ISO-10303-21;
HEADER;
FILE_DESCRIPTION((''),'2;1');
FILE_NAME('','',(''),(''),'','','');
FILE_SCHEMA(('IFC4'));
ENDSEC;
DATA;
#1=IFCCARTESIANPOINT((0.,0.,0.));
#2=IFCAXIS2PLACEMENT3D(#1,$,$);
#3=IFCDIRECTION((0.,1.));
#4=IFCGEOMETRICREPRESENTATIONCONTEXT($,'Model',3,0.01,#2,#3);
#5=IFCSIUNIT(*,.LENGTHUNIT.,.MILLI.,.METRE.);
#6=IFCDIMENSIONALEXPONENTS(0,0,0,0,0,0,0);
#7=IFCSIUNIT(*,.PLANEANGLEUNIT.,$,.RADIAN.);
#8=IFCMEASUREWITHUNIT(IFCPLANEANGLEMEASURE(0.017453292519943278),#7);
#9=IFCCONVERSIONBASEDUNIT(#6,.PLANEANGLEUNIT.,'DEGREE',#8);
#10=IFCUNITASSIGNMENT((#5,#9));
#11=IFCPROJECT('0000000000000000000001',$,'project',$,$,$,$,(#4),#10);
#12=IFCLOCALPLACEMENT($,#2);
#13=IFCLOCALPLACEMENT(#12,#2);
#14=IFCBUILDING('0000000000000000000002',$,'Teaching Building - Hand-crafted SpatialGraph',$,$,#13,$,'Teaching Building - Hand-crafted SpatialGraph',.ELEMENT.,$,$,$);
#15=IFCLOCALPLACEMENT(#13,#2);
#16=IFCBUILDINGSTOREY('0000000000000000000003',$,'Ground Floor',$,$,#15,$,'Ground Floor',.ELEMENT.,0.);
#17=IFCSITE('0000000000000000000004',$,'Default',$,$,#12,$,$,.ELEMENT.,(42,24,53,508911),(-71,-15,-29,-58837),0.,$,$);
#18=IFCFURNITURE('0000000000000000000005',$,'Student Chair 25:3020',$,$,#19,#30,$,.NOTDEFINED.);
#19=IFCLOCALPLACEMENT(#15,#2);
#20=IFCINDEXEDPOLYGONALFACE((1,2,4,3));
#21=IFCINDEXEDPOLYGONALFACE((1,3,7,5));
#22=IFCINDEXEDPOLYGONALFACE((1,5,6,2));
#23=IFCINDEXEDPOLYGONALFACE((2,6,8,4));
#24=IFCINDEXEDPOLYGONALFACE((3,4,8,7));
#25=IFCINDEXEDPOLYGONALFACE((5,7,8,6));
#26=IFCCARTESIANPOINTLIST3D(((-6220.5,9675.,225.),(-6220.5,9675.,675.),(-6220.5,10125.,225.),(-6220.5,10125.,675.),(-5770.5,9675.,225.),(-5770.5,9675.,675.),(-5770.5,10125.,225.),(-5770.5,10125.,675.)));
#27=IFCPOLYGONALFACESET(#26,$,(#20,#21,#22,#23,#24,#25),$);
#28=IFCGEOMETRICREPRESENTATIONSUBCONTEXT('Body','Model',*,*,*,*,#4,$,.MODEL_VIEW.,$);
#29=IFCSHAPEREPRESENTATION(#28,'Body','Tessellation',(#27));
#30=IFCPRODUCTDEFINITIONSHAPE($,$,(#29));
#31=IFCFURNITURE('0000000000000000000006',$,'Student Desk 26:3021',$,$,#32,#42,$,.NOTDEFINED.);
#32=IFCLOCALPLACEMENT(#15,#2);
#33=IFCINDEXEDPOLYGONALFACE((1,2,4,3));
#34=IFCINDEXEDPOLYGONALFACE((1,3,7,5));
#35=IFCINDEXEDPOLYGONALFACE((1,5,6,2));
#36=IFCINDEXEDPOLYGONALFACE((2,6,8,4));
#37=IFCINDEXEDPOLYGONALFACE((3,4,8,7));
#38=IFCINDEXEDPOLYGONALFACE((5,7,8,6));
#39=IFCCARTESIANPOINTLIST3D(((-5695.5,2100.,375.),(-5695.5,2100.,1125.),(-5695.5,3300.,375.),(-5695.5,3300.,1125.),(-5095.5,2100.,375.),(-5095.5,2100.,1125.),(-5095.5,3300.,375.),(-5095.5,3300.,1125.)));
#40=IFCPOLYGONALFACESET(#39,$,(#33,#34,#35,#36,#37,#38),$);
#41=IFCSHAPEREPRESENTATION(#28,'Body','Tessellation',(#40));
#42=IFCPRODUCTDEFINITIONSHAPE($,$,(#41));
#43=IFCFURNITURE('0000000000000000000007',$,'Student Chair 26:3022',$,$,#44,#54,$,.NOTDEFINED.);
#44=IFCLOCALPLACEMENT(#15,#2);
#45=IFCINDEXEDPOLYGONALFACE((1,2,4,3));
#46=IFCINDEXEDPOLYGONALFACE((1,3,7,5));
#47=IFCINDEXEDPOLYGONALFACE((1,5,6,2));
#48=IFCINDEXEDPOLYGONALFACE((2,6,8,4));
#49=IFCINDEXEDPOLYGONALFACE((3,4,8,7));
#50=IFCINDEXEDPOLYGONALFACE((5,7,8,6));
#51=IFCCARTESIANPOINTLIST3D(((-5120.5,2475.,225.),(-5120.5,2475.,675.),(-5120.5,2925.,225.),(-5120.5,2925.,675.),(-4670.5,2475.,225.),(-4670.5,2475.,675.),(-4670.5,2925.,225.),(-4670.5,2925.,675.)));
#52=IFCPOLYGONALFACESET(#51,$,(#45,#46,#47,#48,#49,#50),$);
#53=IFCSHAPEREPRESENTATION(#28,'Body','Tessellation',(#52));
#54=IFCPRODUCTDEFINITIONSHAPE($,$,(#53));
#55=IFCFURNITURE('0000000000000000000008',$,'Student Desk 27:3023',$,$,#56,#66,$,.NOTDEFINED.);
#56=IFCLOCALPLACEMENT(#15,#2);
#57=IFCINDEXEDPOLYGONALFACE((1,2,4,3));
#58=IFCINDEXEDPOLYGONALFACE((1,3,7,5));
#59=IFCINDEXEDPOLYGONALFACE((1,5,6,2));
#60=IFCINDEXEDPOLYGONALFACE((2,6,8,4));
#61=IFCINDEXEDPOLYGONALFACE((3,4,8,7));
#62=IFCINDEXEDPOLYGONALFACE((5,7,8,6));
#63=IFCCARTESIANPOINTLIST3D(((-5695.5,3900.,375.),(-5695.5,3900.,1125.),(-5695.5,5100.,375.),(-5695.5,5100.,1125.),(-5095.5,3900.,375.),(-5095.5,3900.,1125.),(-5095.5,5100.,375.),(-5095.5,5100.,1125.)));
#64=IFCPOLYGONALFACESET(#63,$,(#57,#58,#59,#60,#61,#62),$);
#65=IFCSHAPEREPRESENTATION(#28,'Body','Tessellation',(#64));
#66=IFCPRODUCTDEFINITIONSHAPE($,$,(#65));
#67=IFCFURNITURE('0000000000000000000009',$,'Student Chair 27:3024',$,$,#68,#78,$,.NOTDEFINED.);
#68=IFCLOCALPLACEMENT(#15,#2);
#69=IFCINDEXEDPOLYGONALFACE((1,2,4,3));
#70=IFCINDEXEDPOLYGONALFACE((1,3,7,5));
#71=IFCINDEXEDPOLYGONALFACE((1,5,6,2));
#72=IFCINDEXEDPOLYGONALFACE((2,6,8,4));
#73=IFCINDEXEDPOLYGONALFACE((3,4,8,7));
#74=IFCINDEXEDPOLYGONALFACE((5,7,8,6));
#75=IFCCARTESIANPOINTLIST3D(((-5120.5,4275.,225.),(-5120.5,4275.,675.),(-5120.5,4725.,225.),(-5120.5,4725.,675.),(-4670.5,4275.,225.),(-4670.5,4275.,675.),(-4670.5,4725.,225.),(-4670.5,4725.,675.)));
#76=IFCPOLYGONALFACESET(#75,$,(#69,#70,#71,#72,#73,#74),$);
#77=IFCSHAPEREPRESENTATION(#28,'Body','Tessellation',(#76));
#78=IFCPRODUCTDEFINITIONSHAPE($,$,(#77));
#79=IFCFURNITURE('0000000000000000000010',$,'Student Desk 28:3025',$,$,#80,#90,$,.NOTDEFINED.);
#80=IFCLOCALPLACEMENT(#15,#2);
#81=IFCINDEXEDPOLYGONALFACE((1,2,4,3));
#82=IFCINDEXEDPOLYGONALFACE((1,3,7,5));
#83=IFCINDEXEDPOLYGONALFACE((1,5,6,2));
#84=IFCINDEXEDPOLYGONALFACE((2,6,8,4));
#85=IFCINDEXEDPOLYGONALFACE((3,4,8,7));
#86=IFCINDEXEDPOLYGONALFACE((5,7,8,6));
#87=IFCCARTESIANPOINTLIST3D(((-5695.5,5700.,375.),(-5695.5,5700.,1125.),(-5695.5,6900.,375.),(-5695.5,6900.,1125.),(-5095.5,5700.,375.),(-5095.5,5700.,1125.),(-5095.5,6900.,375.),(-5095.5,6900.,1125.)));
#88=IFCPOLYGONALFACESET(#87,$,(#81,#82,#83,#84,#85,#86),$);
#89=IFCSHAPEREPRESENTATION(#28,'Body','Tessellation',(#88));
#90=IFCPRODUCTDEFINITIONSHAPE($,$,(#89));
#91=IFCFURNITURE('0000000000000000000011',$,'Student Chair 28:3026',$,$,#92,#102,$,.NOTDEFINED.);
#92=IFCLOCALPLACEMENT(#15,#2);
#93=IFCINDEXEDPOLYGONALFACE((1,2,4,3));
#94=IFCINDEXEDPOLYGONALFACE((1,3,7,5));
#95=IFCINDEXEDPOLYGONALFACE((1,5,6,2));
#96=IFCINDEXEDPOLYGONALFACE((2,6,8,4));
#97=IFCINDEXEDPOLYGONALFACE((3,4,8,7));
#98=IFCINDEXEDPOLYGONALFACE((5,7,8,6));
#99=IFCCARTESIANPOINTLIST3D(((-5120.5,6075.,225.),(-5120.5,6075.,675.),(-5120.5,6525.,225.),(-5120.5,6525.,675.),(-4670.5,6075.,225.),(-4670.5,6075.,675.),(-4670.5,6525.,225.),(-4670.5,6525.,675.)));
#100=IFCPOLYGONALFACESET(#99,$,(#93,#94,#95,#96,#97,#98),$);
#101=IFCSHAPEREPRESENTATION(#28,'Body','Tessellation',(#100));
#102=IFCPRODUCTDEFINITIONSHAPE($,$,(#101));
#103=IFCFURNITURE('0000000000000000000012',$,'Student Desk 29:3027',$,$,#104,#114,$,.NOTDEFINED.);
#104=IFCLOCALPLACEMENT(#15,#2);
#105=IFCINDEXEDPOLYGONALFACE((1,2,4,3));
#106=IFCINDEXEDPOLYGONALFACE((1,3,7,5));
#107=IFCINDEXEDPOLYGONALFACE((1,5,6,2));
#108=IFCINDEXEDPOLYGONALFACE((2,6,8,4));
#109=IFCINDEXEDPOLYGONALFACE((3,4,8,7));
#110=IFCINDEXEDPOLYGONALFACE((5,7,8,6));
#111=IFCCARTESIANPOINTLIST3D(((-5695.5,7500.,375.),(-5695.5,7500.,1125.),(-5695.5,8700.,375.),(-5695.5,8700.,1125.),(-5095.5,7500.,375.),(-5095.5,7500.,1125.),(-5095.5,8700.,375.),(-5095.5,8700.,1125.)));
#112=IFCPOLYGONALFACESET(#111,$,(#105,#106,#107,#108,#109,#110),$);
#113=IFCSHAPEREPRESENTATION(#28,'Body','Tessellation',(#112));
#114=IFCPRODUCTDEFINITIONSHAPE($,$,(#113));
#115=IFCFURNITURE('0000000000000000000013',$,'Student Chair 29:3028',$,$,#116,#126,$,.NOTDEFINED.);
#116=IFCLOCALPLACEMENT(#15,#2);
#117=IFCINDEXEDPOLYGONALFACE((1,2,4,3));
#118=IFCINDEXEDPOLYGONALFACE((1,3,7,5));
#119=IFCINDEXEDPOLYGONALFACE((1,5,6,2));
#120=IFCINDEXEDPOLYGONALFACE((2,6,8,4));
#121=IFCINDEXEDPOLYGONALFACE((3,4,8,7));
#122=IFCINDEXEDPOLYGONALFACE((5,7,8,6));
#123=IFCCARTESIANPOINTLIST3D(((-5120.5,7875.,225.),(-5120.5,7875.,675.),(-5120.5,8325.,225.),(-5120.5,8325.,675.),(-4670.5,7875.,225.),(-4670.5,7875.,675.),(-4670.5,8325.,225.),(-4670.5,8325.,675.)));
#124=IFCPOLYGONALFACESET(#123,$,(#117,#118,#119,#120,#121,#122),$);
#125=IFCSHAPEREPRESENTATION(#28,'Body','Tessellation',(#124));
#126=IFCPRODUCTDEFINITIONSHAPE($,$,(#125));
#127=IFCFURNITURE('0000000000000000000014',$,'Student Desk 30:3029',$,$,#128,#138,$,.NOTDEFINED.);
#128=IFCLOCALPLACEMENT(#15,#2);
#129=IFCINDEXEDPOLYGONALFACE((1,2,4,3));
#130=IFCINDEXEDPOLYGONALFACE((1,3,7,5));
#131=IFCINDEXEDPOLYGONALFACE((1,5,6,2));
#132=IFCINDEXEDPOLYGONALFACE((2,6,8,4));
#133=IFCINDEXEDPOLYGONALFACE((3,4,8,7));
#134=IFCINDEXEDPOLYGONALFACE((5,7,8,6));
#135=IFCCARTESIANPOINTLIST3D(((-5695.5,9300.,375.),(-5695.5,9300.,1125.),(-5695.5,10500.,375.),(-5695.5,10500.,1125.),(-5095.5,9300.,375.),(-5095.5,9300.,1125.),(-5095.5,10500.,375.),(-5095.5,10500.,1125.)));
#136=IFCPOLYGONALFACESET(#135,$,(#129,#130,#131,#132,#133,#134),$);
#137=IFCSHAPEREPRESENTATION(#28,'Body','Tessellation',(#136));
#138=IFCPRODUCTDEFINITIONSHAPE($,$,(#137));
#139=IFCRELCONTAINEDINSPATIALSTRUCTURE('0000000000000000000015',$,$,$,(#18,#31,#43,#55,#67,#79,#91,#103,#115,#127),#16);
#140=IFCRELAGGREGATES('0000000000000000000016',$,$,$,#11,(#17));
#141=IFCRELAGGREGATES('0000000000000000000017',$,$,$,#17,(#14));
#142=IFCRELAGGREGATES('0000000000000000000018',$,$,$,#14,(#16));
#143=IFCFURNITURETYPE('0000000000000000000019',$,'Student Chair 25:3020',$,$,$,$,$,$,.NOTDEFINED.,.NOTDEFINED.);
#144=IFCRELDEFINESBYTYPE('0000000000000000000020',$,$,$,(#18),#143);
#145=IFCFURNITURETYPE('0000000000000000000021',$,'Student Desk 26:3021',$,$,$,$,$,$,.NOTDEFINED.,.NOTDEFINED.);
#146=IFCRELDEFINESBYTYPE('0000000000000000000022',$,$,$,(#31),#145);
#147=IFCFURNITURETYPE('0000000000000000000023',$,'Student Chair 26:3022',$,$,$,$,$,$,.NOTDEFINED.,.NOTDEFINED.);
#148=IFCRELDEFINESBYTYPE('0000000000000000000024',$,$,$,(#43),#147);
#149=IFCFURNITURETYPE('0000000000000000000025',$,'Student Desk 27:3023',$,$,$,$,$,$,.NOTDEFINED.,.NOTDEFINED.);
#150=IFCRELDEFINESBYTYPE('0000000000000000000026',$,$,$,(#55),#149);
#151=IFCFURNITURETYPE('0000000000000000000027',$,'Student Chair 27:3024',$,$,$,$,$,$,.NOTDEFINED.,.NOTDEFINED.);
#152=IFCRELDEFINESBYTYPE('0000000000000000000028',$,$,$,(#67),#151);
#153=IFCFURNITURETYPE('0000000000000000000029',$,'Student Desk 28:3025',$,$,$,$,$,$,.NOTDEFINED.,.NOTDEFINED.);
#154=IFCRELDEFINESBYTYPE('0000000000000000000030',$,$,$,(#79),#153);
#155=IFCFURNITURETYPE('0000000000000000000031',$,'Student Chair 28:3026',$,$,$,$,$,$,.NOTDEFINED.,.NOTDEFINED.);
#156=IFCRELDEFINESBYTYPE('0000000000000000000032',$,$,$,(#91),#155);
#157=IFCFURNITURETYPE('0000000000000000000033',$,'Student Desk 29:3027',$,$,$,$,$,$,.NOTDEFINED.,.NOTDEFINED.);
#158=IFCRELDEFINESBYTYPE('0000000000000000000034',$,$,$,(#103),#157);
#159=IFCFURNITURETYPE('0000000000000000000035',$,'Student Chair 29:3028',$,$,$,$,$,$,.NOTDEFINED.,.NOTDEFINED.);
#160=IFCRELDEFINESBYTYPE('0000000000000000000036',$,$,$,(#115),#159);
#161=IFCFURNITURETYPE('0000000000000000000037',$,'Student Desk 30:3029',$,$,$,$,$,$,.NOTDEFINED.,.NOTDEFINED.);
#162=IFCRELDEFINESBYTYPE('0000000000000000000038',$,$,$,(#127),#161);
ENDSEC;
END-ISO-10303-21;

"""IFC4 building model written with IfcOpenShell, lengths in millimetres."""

from ifc_helpers import new_model, entity, si_unit, converted_unit, direction, frame, frame_2d, origin, origin_2d_with_axis, place, context, subcontext, project, spatial, rectangle, extrude, type_object, element, save


model = new_model("IFC4")

# Units and contexts
model_context = context("Model", 3, precision=0.01, world=origin(), true_north=direction((0.0, 1.0)))
body_context = subcontext(model_context, "Body", "Model", "MODEL_VIEW")
ifc_project = project(units=[si_unit("LENGTHUNIT", "METRE", prefix="MILLI"), converted_unit("PLANEANGLEUNIT", "DEGREE", entity("IfcPlaneAngleMeasure", 0.017453292519943278), si_unit("PLANEANGLEUNIT", "RADIAN"), dimensions=[0, 0, 0, 0, 0, 0, 0])], contexts=[model_context])

# Site, building, storey
site_placement = place(None, origin())
site = spatial("IfcSite", under=ifc_project, at=site_placement, Name="Default", CompositionType="ELEMENT", RefLatitude=(42, 24, 53, 508911), RefLongitude=(-71, -15, -29, -58837), RefElevation=0.0)
building_placement = place(site_placement, origin())
building = spatial("IfcBuilding", under=site, at=building_placement, Name="Teaching Building - Hand-crafted SpatialGraph", LongName="Teaching Building - Hand-crafted SpatialGraph", CompositionType="ELEMENT")
storey_placement = place(building_placement, origin())
storey = spatial("IfcBuildingStorey", under=building, at=storey_placement, Name="Ground Floor", LongName="Ground Floor", CompositionType="ELEMENT", Elevation=0.0)

# Furniture
furniture_type_1 = type_object("IfcFurnitureType", Name="Student Chair 25:3020", PredefinedType="NOTDEFINED")
furniture_1_placement = place(storey_placement, origin())
element("IfcFurniture", 1, at=furniture_1_placement, inside=storey, type_object=furniture_type_1, Name="Student Chair 25:3020", PredefinedType="NOTDEFINED", context=body_context, shape_type="SweptSolid", body=[
    extrude(rectangle(XDim=450.0, YDim=450.0, at=frame_2d((0.0, 0.0), x_axis=(1.0, 0.0))), frame((-5995.5, 9900.0, 225.0)), (0.0, 0.0, 1.0), 450.0),
])
furniture_type_2 = type_object("IfcFurnitureType", Name="Student Desk 26:3021", PredefinedType="NOTDEFINED")
furniture_2_placement = place(storey_placement, origin())
element("IfcFurniture", 2, at=furniture_2_placement, inside=storey, type_object=furniture_type_2, Name="Student Desk 26:3021", PredefinedType="NOTDEFINED", context=body_context, shape_type="SweptSolid", body=[
    extrude(rectangle(XDim=1200.0, YDim=600.0, at=origin_2d_with_axis()), frame((-5395.5, 2700.0, 375.0), z_axis=(0.0, 0.0, 1.0), x_axis=(0.0, 1.0, 0.0)), (0.0, 0.0, 1.0), 750.0),
])
furniture_type_3 = type_object("IfcFurnitureType", Name="Student Chair 26:3022", PredefinedType="NOTDEFINED")
furniture_3_placement = place(storey_placement, origin())
element("IfcFurniture", 3, at=furniture_3_placement, inside=storey, type_object=furniture_type_3, Name="Student Chair 26:3022", PredefinedType="NOTDEFINED", context=body_context, shape_type="SweptSolid", body=[
    extrude(rectangle(XDim=450.0, YDim=450.0, at=origin_2d_with_axis()), frame((-4895.5, 2700.0, 225.0)), (0.0, 0.0, 1.0), 450.0),
])
furniture_type_4 = type_object("IfcFurnitureType", Name="Student Desk 27:3023", PredefinedType="NOTDEFINED")
furniture_4_placement = place(storey_placement, origin())
element("IfcFurniture", 4, at=furniture_4_placement, inside=storey, type_object=furniture_type_4, Name="Student Desk 27:3023", PredefinedType="NOTDEFINED", context=body_context, shape_type="SweptSolid", body=[
    extrude(rectangle(XDim=1200.0, YDim=600.0, at=frame_2d((0.0, 0.0), x_axis=(1.0, 0.0))), frame((-5395.5, 4500.0, 375.0), z_axis=(0.0, 0.0, 1.0), x_axis=(0.0, 1.0, 0.0)), (0.0, 0.0, 1.0), 750.0),
])
furniture_type_5 = type_object("IfcFurnitureType", Name="Student Chair 27:3024", PredefinedType="NOTDEFINED")
furniture_5_placement = place(storey_placement, origin())
element("IfcFurniture", 5, at=furniture_5_placement, inside=storey, type_object=furniture_type_5, Name="Student Chair 27:3024", PredefinedType="NOTDEFINED", context=body_context, shape_type="SweptSolid", body=[
    extrude(rectangle(XDim=450.0, YDim=450.0, at=origin_2d_with_axis()), frame((-4895.5, 4500.0, 225.0)), (0.0, 0.0, 1.0), 450.0),
])
furniture_type_6 = type_object("IfcFurnitureType", Name="Student Desk 28:3025", PredefinedType="NOTDEFINED")
furniture_6_placement = place(storey_placement, origin())
element("IfcFurniture", 6, at=furniture_6_placement, inside=storey, type_object=furniture_type_6, Name="Student Desk 28:3025", PredefinedType="NOTDEFINED", context=body_context, shape_type="SweptSolid", body=[
    extrude(rectangle(XDim=1200.0, YDim=600.0, at=origin_2d_with_axis()), frame((-5395.5, 6300.0, 375.0), z_axis=(0.0, 0.0, 1.0), x_axis=(0.0, 1.0, 0.0)), (0.0, 0.0, 1.0), 750.0),
])
furniture_type_7 = type_object("IfcFurnitureType", Name="Student Chair 28:3026", PredefinedType="NOTDEFINED")
furniture_7_placement = place(storey_placement, origin())
element("IfcFurniture", 7, at=furniture_7_placement, inside=storey, type_object=furniture_type_7, Name="Student Chair 28:3026", PredefinedType="NOTDEFINED", context=body_context, shape_type="SweptSolid", body=[
    extrude(rectangle(XDim=450.0, YDim=450.0, at=origin_2d_with_axis()), frame((-4895.5, 6300.0, 225.0)), (0.0, 0.0, 1.0), 450.0),
])
furniture_type_8 = type_object("IfcFurnitureType", Name="Student Desk 29:3027", PredefinedType="NOTDEFINED")
furniture_8_placement = place(storey_placement, origin())
element("IfcFurniture", 8, at=furniture_8_placement, inside=storey, type_object=furniture_type_8, Name="Student Desk 29:3027", PredefinedType="NOTDEFINED", context=body_context, shape_type="SweptSolid", body=[
    extrude(rectangle(XDim=1200.0, YDim=600.0, at=origin_2d_with_axis()), frame((-5395.5, 8100.0, 375.0), z_axis=(0.0, 0.0, 1.0), x_axis=(0.0, 1.0, 0.0)), (0.0, 0.0, 1.0), 750.0),
])
furniture_type_9 = type_object("IfcFurnitureType", Name="Student Chair 29:3028", PredefinedType="NOTDEFINED")
furniture_9_placement = place(storey_placement, origin())
element("IfcFurniture", 9, at=furniture_9_placement, inside=storey, type_object=furniture_type_9, Name="Student Chair 29:3028", PredefinedType="NOTDEFINED", context=body_context, shape_type="SweptSolid", body=[
    extrude(rectangle(XDim=450.0, YDim=450.0, at=origin_2d_with_axis()), frame((-4895.5, 8100.0, 225.0)), (0.0, 0.0, 1.0), 450.0),
])
furniture_type_10 = type_object("IfcFurnitureType", Name="Student Desk 30:3029", PredefinedType="NOTDEFINED")
furniture_10_placement = place(storey_placement, origin())
element("IfcFurniture", 10, at=furniture_10_placement, inside=storey, type_object=furniture_type_10, Name="Student Desk 30:3029", PredefinedType="NOTDEFINED", context=body_context, shape_type="SweptSolid", body=[
    extrude(rectangle(XDim=1200.0, YDim=600.0, at=origin_2d_with_axis()), frame((-5395.5, 9900.0, 375.0), z_axis=(0.0, 0.0, 1.0), x_axis=(0.0, 1.0, 0.0)), (0.0, 0.0, 1.0), 750.0),
])

save(model, "model.ifc")
